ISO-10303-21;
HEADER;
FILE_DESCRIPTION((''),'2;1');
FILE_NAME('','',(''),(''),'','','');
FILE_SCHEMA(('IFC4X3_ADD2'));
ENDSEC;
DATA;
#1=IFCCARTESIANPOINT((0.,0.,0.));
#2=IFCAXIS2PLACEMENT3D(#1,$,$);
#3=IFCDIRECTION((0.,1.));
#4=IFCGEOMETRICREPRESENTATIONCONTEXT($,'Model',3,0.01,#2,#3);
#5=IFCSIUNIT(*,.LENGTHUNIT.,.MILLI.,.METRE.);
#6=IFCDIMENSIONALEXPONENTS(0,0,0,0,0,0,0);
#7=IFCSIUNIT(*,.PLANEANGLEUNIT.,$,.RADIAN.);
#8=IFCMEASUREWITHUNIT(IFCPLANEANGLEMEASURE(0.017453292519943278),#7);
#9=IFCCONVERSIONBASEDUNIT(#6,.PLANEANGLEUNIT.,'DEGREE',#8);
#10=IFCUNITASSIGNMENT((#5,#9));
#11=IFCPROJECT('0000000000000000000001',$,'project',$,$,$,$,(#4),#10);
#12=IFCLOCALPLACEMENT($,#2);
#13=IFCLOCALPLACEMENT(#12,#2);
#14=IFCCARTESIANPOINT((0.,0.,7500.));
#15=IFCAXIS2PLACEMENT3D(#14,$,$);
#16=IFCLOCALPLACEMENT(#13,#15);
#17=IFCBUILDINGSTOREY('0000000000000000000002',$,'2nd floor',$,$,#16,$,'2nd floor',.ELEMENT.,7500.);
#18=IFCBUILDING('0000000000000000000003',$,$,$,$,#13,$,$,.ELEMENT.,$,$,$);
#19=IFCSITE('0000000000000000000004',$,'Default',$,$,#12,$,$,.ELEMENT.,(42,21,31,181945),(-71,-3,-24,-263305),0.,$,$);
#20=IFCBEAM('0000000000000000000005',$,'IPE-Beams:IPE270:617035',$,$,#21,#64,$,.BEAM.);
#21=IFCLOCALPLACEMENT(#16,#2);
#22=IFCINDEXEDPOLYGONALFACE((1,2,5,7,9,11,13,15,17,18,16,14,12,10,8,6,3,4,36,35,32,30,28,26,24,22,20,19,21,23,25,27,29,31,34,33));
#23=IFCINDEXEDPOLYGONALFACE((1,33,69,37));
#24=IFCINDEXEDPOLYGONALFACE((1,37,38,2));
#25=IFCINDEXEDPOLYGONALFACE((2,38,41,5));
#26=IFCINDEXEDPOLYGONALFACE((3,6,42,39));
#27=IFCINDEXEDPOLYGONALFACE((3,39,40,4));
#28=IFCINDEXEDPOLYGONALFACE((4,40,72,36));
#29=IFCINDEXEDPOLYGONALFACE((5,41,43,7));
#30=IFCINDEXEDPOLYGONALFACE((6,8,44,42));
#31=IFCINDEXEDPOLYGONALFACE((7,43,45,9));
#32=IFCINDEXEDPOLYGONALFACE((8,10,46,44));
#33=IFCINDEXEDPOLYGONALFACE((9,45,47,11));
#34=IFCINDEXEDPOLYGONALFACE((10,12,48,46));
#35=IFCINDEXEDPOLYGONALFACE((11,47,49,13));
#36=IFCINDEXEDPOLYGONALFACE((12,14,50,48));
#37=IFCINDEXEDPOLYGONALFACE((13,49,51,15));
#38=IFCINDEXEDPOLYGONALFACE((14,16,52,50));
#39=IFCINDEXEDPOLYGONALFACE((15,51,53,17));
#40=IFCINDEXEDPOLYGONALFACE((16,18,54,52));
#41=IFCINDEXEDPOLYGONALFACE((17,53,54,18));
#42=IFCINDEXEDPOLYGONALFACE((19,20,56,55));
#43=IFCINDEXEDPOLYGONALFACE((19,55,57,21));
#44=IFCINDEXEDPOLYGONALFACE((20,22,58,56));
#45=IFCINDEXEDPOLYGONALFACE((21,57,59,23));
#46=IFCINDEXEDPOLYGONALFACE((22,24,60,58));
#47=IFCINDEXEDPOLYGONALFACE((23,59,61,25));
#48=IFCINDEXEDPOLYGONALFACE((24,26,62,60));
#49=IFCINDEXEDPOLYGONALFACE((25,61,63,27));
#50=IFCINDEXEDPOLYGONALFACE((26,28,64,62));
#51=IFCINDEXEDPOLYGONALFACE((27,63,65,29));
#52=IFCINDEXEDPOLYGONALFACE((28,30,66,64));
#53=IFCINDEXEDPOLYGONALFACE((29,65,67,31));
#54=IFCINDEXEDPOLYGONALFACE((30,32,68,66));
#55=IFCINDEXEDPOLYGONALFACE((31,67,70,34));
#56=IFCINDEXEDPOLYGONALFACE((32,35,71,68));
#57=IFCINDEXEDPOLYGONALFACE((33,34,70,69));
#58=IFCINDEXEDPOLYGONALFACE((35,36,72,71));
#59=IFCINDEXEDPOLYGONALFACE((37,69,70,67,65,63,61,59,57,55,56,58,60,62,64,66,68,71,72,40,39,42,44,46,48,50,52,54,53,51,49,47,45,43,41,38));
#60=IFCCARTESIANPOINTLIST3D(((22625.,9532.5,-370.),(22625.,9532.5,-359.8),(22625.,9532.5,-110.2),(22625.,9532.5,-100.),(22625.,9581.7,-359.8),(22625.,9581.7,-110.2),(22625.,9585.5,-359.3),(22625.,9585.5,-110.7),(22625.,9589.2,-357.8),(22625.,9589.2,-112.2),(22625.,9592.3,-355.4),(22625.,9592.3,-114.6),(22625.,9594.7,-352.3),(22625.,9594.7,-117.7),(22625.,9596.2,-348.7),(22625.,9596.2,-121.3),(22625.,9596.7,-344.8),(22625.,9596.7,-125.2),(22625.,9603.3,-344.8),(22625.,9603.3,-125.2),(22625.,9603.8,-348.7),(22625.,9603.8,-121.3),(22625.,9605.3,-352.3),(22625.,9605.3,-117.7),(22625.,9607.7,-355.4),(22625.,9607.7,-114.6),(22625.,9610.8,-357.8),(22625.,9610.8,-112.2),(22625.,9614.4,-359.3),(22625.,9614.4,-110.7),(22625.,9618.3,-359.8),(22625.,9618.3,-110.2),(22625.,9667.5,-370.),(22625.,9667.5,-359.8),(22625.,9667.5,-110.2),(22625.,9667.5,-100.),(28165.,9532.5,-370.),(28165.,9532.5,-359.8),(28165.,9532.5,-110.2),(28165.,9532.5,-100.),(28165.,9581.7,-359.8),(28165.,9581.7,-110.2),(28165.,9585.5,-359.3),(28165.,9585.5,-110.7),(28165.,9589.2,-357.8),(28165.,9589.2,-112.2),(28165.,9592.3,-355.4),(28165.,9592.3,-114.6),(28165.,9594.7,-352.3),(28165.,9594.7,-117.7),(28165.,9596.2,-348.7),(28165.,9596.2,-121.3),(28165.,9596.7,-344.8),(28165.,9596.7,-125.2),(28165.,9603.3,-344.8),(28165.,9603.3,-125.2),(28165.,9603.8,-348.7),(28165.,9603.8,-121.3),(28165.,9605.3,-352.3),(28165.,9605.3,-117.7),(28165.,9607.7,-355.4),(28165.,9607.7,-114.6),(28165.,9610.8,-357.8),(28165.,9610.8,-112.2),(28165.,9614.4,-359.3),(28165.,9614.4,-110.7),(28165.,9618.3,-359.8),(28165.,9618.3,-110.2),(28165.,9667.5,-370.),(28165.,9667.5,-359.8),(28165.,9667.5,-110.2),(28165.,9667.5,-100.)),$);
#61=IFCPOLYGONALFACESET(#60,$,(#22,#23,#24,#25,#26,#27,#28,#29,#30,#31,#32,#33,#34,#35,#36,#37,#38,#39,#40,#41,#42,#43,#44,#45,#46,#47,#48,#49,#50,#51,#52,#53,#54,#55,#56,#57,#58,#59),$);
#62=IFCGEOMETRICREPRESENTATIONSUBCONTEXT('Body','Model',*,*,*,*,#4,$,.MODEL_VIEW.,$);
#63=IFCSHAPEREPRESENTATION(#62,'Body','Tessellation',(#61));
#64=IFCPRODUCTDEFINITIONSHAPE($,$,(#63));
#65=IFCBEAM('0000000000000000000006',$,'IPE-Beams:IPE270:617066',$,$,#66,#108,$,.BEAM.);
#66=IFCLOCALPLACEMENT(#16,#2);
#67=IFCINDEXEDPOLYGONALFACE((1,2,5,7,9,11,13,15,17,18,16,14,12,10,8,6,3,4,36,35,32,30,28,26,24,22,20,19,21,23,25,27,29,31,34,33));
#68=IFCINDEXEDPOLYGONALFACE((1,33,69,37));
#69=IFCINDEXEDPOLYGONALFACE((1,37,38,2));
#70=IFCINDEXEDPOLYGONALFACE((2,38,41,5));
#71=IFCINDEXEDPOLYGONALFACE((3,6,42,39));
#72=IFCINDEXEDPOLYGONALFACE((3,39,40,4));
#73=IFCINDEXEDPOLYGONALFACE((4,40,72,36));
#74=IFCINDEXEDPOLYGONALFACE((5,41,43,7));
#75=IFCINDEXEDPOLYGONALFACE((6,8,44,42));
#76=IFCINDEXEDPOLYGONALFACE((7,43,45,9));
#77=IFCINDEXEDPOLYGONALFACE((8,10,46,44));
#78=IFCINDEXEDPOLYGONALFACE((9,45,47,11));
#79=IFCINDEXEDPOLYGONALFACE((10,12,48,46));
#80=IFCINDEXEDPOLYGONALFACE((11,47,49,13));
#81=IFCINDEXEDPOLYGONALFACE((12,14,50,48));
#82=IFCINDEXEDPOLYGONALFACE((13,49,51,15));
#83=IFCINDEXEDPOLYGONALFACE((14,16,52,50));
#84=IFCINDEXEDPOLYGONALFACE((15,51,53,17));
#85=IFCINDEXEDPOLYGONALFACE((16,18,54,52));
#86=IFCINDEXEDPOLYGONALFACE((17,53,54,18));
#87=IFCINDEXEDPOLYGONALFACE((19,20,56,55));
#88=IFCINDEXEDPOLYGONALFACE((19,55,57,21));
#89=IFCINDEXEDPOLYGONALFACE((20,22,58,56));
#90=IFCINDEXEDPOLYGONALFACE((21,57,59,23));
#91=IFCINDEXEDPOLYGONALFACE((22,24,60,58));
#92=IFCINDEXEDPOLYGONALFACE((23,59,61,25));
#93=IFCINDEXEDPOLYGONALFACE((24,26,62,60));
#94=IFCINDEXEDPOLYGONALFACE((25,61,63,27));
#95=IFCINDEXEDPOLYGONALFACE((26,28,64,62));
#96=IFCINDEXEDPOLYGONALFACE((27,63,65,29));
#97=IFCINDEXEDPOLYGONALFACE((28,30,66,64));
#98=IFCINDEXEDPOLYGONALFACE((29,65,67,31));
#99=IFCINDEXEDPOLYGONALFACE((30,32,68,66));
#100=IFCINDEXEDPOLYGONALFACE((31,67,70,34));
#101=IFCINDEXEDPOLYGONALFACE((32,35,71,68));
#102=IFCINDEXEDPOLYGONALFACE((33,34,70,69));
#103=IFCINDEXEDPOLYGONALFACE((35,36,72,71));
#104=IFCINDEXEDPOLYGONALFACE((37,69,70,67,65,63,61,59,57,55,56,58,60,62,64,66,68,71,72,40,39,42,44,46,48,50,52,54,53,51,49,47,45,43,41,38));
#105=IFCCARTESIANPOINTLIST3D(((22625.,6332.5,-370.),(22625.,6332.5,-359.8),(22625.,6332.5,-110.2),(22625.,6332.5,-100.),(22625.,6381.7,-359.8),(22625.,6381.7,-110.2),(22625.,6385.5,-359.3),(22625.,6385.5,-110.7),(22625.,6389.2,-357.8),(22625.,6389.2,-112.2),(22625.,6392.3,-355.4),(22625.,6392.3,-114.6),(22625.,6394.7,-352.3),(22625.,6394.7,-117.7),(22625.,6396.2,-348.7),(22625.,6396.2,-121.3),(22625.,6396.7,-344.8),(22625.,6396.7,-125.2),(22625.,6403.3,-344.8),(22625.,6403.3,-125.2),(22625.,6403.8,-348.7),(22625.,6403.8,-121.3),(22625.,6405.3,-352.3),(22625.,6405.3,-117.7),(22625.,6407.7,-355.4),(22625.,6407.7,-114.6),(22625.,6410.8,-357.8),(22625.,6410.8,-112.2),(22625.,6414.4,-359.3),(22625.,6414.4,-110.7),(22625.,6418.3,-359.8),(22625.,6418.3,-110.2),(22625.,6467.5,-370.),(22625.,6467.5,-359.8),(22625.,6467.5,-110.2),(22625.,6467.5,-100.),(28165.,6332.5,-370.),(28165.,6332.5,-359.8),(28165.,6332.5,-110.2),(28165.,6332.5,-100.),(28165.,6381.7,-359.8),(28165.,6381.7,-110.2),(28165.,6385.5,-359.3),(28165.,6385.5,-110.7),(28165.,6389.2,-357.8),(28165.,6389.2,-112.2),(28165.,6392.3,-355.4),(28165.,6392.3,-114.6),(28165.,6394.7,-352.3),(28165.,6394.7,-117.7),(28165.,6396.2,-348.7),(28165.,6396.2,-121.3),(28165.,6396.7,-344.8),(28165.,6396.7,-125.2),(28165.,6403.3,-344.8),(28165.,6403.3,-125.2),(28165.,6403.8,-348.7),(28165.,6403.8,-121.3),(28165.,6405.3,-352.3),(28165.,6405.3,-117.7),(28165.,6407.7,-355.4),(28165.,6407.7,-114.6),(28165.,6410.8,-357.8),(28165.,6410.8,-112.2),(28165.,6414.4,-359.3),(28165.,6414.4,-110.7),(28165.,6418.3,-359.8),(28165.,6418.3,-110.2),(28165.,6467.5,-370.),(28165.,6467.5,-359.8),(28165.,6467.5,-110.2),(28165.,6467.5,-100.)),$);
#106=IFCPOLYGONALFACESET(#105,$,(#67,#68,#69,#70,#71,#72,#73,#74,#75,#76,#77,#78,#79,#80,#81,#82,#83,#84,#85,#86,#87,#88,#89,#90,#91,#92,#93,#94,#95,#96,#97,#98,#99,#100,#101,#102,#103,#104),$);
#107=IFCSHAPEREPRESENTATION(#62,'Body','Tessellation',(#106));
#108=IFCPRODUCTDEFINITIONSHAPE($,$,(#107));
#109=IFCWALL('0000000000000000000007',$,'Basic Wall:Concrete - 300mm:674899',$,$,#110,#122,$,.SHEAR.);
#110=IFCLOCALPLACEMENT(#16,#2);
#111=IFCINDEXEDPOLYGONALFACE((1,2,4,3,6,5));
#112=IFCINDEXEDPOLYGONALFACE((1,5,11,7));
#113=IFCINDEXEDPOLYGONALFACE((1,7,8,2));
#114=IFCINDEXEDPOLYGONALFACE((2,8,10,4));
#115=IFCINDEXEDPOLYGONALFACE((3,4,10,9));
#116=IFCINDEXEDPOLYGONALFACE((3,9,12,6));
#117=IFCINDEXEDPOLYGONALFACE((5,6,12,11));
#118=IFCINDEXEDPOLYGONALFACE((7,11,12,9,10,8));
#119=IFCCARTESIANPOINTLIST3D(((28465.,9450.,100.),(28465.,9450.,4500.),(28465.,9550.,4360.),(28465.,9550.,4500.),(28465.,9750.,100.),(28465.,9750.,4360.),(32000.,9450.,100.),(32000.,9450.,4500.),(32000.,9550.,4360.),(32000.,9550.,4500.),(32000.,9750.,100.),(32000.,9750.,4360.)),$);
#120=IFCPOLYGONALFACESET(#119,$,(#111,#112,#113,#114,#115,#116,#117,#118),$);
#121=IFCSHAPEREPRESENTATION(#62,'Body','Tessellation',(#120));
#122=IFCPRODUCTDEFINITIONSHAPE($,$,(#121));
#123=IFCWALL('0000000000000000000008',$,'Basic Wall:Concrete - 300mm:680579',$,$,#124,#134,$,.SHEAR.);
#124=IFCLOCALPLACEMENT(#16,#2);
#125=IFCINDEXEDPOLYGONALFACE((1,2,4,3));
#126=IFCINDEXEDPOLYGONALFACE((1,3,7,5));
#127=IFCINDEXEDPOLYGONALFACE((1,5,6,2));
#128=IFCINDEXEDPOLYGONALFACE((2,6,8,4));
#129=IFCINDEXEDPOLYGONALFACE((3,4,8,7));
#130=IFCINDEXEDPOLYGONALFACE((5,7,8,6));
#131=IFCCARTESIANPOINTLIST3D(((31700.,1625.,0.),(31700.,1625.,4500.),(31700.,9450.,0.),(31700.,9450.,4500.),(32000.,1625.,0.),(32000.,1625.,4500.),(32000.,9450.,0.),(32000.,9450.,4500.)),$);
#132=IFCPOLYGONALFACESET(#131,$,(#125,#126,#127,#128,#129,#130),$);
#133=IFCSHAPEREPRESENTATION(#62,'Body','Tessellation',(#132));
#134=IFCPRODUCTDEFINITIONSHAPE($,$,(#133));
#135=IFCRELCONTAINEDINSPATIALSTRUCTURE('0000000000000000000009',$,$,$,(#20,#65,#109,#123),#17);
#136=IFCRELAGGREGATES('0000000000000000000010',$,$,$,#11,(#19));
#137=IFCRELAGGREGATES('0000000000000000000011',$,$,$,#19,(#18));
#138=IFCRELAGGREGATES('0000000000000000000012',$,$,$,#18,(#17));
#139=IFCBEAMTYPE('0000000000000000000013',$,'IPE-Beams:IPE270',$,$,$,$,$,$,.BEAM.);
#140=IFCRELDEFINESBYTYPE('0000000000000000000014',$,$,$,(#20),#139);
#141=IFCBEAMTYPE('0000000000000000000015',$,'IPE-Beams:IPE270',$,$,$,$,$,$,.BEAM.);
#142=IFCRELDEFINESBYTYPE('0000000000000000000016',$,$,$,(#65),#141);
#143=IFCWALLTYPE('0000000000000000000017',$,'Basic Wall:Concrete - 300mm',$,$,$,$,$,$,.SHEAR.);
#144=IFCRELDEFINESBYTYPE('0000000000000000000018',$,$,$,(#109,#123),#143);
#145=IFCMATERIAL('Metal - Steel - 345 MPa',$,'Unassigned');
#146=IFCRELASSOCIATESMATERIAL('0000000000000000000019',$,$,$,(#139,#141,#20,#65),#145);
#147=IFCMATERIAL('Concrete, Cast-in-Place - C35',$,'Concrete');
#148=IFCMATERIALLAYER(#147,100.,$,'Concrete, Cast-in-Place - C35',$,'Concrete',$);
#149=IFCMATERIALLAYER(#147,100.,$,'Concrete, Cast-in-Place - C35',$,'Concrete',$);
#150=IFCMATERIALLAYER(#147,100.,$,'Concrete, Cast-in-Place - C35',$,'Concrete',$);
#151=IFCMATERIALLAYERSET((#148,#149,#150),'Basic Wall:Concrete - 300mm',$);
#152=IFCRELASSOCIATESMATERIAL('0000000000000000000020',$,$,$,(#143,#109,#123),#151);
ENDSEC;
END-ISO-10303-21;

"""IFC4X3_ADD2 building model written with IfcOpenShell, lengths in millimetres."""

from ifc_helpers import new_model, entity, si_unit, converted_unit, direction, frame, frame_2d, origin, place, context, subcontext, project, spatial, polyline, circle_curve, parameter, trimmed, segment, composite_curve, rectangle, outline, extrude, clip, bounded_halfspace, source, transform, mapped, material, layer, layer_set, material_profile, profile_set, profile_usage, type_object, type_shapes, element, save


model = new_model("IFC4X3_ADD2")

# Units and contexts
model_context = context("Model", 3, precision=0.01, world=origin(), true_north=direction((0.0, 1.0)))
body_context = subcontext(model_context, "Body", "Model", "MODEL_VIEW")
ifc_project = project(units=[si_unit("LENGTHUNIT", "METRE", prefix="MILLI"), converted_unit("PLANEANGLEUNIT", "DEGREE", entity("IfcPlaneAngleMeasure", 0.017453292519943278), si_unit("PLANEANGLEUNIT", "RADIAN"), dimensions=[0, 0, 0, 0, 0, 0, 0])], contexts=[model_context])

# Site, building, storey
site_placement = place(None, origin())
site = spatial("IfcSite", under=ifc_project, at=site_placement, Name="Default", CompositionType="ELEMENT", RefLatitude=(42, 21, 31, 181945), RefLongitude=(-71, -3, -24, -263305), RefElevation=0.0)
building_placement = place(site_placement, origin())
building = spatial("IfcBuilding", under=site, at=building_placement, CompositionType="ELEMENT")
storey_placement = place(building_placement, frame((0.0, 0.0, 7500.0)))
storey = spatial("IfcBuildingStorey", under=building, at=storey_placement, Name="2nd floor", LongName="2nd floor", CompositionType="ELEMENT", Elevation=7500.0)

# Beams
ifc_material_1 = material(Name="Metal - Steel - 345 MPa", Category="Unassigned")
ifc_material_profile_1 = material_profile(ifc_material_1, outline(composite_curve([segment(polyline([(-67.5, -124.8), (-67.5, -135.0)]), True, "CONTINUOUS"), segment(polyline([(-67.5, -135.0), (67.5, -135.0)]), True, "CONTINUOUS"), segment(polyline([(67.5, -135.0), (67.5, -124.8)]), True, "CONTINUOUS"), segment(polyline([(67.5, -124.8), (18.3, -124.8)]), True, "CONTINUOUS"), segment(trimmed(circle_curve(frame_2d((18.3, -109.8), x_axis=(1.0, 0.0)), 15.0), [parameter(180.0)], [parameter(270.0)], True, "PARAMETER"), False, "CONTINUOUS"), segment(polyline([(3.3, -109.8), (3.3, 109.8)]), True, "CONTINUOUS"), segment(trimmed(circle_curve(frame_2d((18.3, 109.8), x_axis=(1.0, 0.0)), 15.0), [parameter(90.0)], [parameter(180.0)], True, "PARAMETER"), False, "CONTINUOUS"), segment(polyline([(18.3, 124.8), (67.5, 124.8)]), True, "CONTINUOUS"), segment(polyline([(67.5, 124.8), (67.5, 135.0)]), True, "CONTINUOUS"), segment(polyline([(67.5, 135.0), (-67.5, 135.0)]), True, "CONTINUOUS"), segment(polyline([(-67.5, 135.0), (-67.5, 124.8)]), True, "CONTINUOUS"), segment(polyline([(-67.5, 124.8), (-18.3, 124.8)]), True, "CONTINUOUS"), segment(trimmed(circle_curve(frame_2d((-18.3, 109.8), x_axis=(1.0, 0.0)), 15.0), [parameter(360.0)], [parameter(90.0)], True, "PARAMETER"), False, "CONTINUOUS"), segment(polyline([(-3.3, 109.8), (-3.3, -109.8)]), True, "CONTINUOUS"), segment(trimmed(circle_curve(frame_2d((-18.3, -109.8), x_axis=(1.0, 0.0)), 15.0), [parameter(270.0)], [parameter(0.0)], True, "PARAMETER"), False, "CONTINUOUS"), segment(polyline([(-18.3, -124.8), (-67.5, -124.8)]), True, "CONTINUOUS")], self_intersect=False)), Name="IPE270")
ifc_profile_set_1 = profile_set([ifc_material_profile_1], Name="IPE270")
ifc_profile_usage_1 = profile_usage(ifc_profile_set_1, cardinal=8)
beam_type_1 = type_object("IfcBeamType", Name="IPE-Beams:IPE270", PredefinedType="BEAM", material=ifc_profile_set_1)
shared_shape_1 = source(origin(), body_context, "Body", "SweptSolid", [
    extrude(outline(composite_curve([segment(polyline([(-67.5, -124.8), (-67.5, -135.0)]), True, "CONTINUOUS"), segment(polyline([(-67.5, -135.0), (67.5, -135.0)]), True, "CONTINUOUS"), segment(polyline([(67.5, -135.0), (67.5, -124.8)]), True, "CONTINUOUS"), segment(polyline([(67.5, -124.8), (18.3, -124.8)]), True, "CONTINUOUS"), segment(trimmed(circle_curve(frame_2d((18.3, -109.8), x_axis=(1.0, 0.0)), 15.0), [parameter(180.0)], [parameter(270.0)], True, "PARAMETER"), False, "CONTINUOUS"), segment(polyline([(3.3, -109.8), (3.3, 109.8)]), True, "CONTINUOUS"), segment(trimmed(circle_curve(frame_2d((18.3, 109.8), x_axis=(1.0, 0.0)), 15.0), [parameter(90.0)], [parameter(180.0)], True, "PARAMETER"), False, "CONTINUOUS"), segment(polyline([(18.3, 124.8), (67.5, 124.8)]), True, "CONTINUOUS"), segment(polyline([(67.5, 124.8), (67.5, 135.0)]), True, "CONTINUOUS"), segment(polyline([(67.5, 135.0), (-67.5, 135.0)]), True, "CONTINUOUS"), segment(polyline([(-67.5, 135.0), (-67.5, 124.8)]), True, "CONTINUOUS"), segment(polyline([(-67.5, 124.8), (-18.3, 124.8)]), True, "CONTINUOUS"), segment(trimmed(circle_curve(frame_2d((-18.3, 109.8), x_axis=(1.0, 0.0)), 15.0), [parameter(360.0)], [parameter(90.0)], True, "PARAMETER"), False, "CONTINUOUS"), segment(polyline([(-3.3, 109.8), (-3.3, -109.8)]), True, "CONTINUOUS"), segment(trimmed(circle_curve(frame_2d((-18.3, -109.8), x_axis=(1.0, 0.0)), 15.0), [parameter(270.0)], [parameter(0.0)], True, "PARAMETER"), False, "CONTINUOUS"), segment(polyline([(-18.3, -124.8), (-67.5, -124.8)]), True, "CONTINUOUS")], self_intersect=False)), frame((-2820.0, 0.0, 0.0), z_axis=(-1.0, 0.0, 0.0), x_axis=(0.0, -1.0, 0.0)), (0.0, 0.0, -1.0), 5540.0),
])
type_shapes(beam_type_1, [shared_shape_1])
beam_1_placement = place(storey_placement, frame((25445.0, 9600.0, -235.0)))
element("IfcBeam", 1, at=beam_1_placement, inside=storey, type_object=beam_type_1, material=ifc_profile_usage_1, Name="IPE-Beams:IPE270:617035", PredefinedType="BEAM", context=body_context, shape_type="MappedRepresentation", body=[
    mapped(shared_shape_1, transform((0.0, 0.0, 0.0), scale=1.0)),
])
beam_type_2 = type_object("IfcBeamType", Name="IPE-Beams:IPE270", PredefinedType="BEAM", material=ifc_profile_set_1)
shared_shape_2 = source(origin(), body_context, "Body", "SweptSolid", [
    extrude(outline(composite_curve([segment(polyline([(-67.5, -124.8), (-67.5, -135.0)]), True, "CONTINUOUS"), segment(polyline([(-67.5, -135.0), (67.5, -135.0)]), True, "CONTINUOUS"), segment(polyline([(67.5, -135.0), (67.5, -124.8)]), True, "CONTINUOUS"), segment(polyline([(67.5, -124.8), (18.3, -124.8)]), True, "CONTINUOUS"), segment(trimmed(circle_curve(frame_2d((18.3, -109.8), x_axis=(1.0, 0.0)), 15.0), [parameter(180.0)], [parameter(270.0)], True, "PARAMETER"), False, "CONTINUOUS"), segment(polyline([(3.3, -109.8), (3.3, 109.8)]), True, "CONTINUOUS"), segment(trimmed(circle_curve(frame_2d((18.3, 109.8), x_axis=(1.0, 0.0)), 15.0), [parameter(90.0)], [parameter(180.0)], True, "PARAMETER"), False, "CONTINUOUS"), segment(polyline([(18.3, 124.8), (67.5, 124.8)]), True, "CONTINUOUS"), segment(polyline([(67.5, 124.8), (67.5, 135.0)]), True, "CONTINUOUS"), segment(polyline([(67.5, 135.0), (-67.5, 135.0)]), True, "CONTINUOUS"), segment(polyline([(-67.5, 135.0), (-67.5, 124.8)]), True, "CONTINUOUS"), segment(polyline([(-67.5, 124.8), (-18.3, 124.8)]), True, "CONTINUOUS"), segment(trimmed(circle_curve(frame_2d((-18.3, 109.8), x_axis=(1.0, 0.0)), 15.0), [parameter(360.0)], [parameter(90.0)], True, "PARAMETER"), False, "CONTINUOUS"), segment(polyline([(-3.3, 109.8), (-3.3, -109.8)]), True, "CONTINUOUS"), segment(trimmed(circle_curve(frame_2d((-18.3, -109.8), x_axis=(1.0, 0.0)), 15.0), [parameter(270.0)], [parameter(0.0)], True, "PARAMETER"), False, "CONTINUOUS"), segment(polyline([(-18.3, -124.8), (-67.5, -124.8)]), True, "CONTINUOUS")], self_intersect=False)), frame((-2820.0, 0.0, 0.0), z_axis=(-1.0, 0.0, 0.0), x_axis=(0.0, -1.0, 0.0)), (0.0, 0.0, -1.0), 5540.0),
])
type_shapes(beam_type_2, [shared_shape_2])
beam_2_placement = place(storey_placement, frame((25445.0, 6400.0, -235.0)))
element("IfcBeam", 2, at=beam_2_placement, inside=storey, type_object=beam_type_2, material=ifc_profile_usage_1, Name="IPE-Beams:IPE270:617066", PredefinedType="BEAM", context=body_context, shape_type="MappedRepresentation", body=[
    mapped(shared_shape_2, transform((0.0, 0.0, 0.0), scale=1.0)),
])

# Walls
ifc_material_2 = material(Name="Concrete, Cast-in-Place - C35", Category="Concrete")
ifc_layer_1 = layer(ifc_material_2, 100.0, Name="Concrete, Cast-in-Place - C35", Category="Concrete")
ifc_layer_2 = layer(ifc_material_2, 100.0, Name="Concrete, Cast-in-Place - C35", Category="Concrete")
ifc_layer_3 = layer(ifc_material_2, 100.0, Name="Concrete, Cast-in-Place - C35", Category="Concrete")
ifc_layer_set = layer_set([ifc_layer_1, ifc_layer_2, ifc_layer_3], Name="Basic Wall:Concrete - 300mm")
wall_type = type_object("IfcWallType", Name="Basic Wall:Concrete - 300mm", PredefinedType="SHEAR", material=ifc_layer_set)
wall_1_placement = place(storey_placement, frame((28465.0, 9600.0, 100.0)))
element("IfcWall", 3, at=wall_1_placement, inside=storey, type_object=wall_type, material=ifc_layer_set, Name="Basic Wall:Concrete - 300mm:674899", PredefinedType="SHEAR", context=body_context, shape_type="Clipping", body=[
    clip(extrude(rectangle(XDim=3535.0, YDim=300.0, at=frame_2d((1767.5, 0.0), x_axis=(-1.0, 0.0))), origin(), (0.0, 0.0, 1.0), 4400.0), bounded_halfspace(frame((3535.0, -50.0, 4260.0)), False, frame((3535.0, -50.0, 4260.0)), polyline([(0.0, 0.0), (0.0, 200.0), (-3535.0, 200.0), (-3535.0, 0.0), (0.0, 0.0)]))),
])
wall_2_placement = place(storey_placement, frame((31850.0, 9450.0, 0.0), z_axis=(0.0, 0.0, 1.0), x_axis=(0.0, -1.0, 0.0)))
element("IfcWall", 4, at=wall_2_placement, inside=storey, type_object=wall_type, material=ifc_layer_set, Name="Basic Wall:Concrete - 300mm:680579", PredefinedType="SHEAR", context=body_context, shape_type="SweptSolid", body=[
    extrude(rectangle(XDim=7825.0, YDim=300.0, at=frame_2d((3912.5, 0.0), x_axis=(-1.0, 0.0))), origin(), (0.0, 0.0, 1.0), 4500.0),
])

save(model, "model.ifc")
